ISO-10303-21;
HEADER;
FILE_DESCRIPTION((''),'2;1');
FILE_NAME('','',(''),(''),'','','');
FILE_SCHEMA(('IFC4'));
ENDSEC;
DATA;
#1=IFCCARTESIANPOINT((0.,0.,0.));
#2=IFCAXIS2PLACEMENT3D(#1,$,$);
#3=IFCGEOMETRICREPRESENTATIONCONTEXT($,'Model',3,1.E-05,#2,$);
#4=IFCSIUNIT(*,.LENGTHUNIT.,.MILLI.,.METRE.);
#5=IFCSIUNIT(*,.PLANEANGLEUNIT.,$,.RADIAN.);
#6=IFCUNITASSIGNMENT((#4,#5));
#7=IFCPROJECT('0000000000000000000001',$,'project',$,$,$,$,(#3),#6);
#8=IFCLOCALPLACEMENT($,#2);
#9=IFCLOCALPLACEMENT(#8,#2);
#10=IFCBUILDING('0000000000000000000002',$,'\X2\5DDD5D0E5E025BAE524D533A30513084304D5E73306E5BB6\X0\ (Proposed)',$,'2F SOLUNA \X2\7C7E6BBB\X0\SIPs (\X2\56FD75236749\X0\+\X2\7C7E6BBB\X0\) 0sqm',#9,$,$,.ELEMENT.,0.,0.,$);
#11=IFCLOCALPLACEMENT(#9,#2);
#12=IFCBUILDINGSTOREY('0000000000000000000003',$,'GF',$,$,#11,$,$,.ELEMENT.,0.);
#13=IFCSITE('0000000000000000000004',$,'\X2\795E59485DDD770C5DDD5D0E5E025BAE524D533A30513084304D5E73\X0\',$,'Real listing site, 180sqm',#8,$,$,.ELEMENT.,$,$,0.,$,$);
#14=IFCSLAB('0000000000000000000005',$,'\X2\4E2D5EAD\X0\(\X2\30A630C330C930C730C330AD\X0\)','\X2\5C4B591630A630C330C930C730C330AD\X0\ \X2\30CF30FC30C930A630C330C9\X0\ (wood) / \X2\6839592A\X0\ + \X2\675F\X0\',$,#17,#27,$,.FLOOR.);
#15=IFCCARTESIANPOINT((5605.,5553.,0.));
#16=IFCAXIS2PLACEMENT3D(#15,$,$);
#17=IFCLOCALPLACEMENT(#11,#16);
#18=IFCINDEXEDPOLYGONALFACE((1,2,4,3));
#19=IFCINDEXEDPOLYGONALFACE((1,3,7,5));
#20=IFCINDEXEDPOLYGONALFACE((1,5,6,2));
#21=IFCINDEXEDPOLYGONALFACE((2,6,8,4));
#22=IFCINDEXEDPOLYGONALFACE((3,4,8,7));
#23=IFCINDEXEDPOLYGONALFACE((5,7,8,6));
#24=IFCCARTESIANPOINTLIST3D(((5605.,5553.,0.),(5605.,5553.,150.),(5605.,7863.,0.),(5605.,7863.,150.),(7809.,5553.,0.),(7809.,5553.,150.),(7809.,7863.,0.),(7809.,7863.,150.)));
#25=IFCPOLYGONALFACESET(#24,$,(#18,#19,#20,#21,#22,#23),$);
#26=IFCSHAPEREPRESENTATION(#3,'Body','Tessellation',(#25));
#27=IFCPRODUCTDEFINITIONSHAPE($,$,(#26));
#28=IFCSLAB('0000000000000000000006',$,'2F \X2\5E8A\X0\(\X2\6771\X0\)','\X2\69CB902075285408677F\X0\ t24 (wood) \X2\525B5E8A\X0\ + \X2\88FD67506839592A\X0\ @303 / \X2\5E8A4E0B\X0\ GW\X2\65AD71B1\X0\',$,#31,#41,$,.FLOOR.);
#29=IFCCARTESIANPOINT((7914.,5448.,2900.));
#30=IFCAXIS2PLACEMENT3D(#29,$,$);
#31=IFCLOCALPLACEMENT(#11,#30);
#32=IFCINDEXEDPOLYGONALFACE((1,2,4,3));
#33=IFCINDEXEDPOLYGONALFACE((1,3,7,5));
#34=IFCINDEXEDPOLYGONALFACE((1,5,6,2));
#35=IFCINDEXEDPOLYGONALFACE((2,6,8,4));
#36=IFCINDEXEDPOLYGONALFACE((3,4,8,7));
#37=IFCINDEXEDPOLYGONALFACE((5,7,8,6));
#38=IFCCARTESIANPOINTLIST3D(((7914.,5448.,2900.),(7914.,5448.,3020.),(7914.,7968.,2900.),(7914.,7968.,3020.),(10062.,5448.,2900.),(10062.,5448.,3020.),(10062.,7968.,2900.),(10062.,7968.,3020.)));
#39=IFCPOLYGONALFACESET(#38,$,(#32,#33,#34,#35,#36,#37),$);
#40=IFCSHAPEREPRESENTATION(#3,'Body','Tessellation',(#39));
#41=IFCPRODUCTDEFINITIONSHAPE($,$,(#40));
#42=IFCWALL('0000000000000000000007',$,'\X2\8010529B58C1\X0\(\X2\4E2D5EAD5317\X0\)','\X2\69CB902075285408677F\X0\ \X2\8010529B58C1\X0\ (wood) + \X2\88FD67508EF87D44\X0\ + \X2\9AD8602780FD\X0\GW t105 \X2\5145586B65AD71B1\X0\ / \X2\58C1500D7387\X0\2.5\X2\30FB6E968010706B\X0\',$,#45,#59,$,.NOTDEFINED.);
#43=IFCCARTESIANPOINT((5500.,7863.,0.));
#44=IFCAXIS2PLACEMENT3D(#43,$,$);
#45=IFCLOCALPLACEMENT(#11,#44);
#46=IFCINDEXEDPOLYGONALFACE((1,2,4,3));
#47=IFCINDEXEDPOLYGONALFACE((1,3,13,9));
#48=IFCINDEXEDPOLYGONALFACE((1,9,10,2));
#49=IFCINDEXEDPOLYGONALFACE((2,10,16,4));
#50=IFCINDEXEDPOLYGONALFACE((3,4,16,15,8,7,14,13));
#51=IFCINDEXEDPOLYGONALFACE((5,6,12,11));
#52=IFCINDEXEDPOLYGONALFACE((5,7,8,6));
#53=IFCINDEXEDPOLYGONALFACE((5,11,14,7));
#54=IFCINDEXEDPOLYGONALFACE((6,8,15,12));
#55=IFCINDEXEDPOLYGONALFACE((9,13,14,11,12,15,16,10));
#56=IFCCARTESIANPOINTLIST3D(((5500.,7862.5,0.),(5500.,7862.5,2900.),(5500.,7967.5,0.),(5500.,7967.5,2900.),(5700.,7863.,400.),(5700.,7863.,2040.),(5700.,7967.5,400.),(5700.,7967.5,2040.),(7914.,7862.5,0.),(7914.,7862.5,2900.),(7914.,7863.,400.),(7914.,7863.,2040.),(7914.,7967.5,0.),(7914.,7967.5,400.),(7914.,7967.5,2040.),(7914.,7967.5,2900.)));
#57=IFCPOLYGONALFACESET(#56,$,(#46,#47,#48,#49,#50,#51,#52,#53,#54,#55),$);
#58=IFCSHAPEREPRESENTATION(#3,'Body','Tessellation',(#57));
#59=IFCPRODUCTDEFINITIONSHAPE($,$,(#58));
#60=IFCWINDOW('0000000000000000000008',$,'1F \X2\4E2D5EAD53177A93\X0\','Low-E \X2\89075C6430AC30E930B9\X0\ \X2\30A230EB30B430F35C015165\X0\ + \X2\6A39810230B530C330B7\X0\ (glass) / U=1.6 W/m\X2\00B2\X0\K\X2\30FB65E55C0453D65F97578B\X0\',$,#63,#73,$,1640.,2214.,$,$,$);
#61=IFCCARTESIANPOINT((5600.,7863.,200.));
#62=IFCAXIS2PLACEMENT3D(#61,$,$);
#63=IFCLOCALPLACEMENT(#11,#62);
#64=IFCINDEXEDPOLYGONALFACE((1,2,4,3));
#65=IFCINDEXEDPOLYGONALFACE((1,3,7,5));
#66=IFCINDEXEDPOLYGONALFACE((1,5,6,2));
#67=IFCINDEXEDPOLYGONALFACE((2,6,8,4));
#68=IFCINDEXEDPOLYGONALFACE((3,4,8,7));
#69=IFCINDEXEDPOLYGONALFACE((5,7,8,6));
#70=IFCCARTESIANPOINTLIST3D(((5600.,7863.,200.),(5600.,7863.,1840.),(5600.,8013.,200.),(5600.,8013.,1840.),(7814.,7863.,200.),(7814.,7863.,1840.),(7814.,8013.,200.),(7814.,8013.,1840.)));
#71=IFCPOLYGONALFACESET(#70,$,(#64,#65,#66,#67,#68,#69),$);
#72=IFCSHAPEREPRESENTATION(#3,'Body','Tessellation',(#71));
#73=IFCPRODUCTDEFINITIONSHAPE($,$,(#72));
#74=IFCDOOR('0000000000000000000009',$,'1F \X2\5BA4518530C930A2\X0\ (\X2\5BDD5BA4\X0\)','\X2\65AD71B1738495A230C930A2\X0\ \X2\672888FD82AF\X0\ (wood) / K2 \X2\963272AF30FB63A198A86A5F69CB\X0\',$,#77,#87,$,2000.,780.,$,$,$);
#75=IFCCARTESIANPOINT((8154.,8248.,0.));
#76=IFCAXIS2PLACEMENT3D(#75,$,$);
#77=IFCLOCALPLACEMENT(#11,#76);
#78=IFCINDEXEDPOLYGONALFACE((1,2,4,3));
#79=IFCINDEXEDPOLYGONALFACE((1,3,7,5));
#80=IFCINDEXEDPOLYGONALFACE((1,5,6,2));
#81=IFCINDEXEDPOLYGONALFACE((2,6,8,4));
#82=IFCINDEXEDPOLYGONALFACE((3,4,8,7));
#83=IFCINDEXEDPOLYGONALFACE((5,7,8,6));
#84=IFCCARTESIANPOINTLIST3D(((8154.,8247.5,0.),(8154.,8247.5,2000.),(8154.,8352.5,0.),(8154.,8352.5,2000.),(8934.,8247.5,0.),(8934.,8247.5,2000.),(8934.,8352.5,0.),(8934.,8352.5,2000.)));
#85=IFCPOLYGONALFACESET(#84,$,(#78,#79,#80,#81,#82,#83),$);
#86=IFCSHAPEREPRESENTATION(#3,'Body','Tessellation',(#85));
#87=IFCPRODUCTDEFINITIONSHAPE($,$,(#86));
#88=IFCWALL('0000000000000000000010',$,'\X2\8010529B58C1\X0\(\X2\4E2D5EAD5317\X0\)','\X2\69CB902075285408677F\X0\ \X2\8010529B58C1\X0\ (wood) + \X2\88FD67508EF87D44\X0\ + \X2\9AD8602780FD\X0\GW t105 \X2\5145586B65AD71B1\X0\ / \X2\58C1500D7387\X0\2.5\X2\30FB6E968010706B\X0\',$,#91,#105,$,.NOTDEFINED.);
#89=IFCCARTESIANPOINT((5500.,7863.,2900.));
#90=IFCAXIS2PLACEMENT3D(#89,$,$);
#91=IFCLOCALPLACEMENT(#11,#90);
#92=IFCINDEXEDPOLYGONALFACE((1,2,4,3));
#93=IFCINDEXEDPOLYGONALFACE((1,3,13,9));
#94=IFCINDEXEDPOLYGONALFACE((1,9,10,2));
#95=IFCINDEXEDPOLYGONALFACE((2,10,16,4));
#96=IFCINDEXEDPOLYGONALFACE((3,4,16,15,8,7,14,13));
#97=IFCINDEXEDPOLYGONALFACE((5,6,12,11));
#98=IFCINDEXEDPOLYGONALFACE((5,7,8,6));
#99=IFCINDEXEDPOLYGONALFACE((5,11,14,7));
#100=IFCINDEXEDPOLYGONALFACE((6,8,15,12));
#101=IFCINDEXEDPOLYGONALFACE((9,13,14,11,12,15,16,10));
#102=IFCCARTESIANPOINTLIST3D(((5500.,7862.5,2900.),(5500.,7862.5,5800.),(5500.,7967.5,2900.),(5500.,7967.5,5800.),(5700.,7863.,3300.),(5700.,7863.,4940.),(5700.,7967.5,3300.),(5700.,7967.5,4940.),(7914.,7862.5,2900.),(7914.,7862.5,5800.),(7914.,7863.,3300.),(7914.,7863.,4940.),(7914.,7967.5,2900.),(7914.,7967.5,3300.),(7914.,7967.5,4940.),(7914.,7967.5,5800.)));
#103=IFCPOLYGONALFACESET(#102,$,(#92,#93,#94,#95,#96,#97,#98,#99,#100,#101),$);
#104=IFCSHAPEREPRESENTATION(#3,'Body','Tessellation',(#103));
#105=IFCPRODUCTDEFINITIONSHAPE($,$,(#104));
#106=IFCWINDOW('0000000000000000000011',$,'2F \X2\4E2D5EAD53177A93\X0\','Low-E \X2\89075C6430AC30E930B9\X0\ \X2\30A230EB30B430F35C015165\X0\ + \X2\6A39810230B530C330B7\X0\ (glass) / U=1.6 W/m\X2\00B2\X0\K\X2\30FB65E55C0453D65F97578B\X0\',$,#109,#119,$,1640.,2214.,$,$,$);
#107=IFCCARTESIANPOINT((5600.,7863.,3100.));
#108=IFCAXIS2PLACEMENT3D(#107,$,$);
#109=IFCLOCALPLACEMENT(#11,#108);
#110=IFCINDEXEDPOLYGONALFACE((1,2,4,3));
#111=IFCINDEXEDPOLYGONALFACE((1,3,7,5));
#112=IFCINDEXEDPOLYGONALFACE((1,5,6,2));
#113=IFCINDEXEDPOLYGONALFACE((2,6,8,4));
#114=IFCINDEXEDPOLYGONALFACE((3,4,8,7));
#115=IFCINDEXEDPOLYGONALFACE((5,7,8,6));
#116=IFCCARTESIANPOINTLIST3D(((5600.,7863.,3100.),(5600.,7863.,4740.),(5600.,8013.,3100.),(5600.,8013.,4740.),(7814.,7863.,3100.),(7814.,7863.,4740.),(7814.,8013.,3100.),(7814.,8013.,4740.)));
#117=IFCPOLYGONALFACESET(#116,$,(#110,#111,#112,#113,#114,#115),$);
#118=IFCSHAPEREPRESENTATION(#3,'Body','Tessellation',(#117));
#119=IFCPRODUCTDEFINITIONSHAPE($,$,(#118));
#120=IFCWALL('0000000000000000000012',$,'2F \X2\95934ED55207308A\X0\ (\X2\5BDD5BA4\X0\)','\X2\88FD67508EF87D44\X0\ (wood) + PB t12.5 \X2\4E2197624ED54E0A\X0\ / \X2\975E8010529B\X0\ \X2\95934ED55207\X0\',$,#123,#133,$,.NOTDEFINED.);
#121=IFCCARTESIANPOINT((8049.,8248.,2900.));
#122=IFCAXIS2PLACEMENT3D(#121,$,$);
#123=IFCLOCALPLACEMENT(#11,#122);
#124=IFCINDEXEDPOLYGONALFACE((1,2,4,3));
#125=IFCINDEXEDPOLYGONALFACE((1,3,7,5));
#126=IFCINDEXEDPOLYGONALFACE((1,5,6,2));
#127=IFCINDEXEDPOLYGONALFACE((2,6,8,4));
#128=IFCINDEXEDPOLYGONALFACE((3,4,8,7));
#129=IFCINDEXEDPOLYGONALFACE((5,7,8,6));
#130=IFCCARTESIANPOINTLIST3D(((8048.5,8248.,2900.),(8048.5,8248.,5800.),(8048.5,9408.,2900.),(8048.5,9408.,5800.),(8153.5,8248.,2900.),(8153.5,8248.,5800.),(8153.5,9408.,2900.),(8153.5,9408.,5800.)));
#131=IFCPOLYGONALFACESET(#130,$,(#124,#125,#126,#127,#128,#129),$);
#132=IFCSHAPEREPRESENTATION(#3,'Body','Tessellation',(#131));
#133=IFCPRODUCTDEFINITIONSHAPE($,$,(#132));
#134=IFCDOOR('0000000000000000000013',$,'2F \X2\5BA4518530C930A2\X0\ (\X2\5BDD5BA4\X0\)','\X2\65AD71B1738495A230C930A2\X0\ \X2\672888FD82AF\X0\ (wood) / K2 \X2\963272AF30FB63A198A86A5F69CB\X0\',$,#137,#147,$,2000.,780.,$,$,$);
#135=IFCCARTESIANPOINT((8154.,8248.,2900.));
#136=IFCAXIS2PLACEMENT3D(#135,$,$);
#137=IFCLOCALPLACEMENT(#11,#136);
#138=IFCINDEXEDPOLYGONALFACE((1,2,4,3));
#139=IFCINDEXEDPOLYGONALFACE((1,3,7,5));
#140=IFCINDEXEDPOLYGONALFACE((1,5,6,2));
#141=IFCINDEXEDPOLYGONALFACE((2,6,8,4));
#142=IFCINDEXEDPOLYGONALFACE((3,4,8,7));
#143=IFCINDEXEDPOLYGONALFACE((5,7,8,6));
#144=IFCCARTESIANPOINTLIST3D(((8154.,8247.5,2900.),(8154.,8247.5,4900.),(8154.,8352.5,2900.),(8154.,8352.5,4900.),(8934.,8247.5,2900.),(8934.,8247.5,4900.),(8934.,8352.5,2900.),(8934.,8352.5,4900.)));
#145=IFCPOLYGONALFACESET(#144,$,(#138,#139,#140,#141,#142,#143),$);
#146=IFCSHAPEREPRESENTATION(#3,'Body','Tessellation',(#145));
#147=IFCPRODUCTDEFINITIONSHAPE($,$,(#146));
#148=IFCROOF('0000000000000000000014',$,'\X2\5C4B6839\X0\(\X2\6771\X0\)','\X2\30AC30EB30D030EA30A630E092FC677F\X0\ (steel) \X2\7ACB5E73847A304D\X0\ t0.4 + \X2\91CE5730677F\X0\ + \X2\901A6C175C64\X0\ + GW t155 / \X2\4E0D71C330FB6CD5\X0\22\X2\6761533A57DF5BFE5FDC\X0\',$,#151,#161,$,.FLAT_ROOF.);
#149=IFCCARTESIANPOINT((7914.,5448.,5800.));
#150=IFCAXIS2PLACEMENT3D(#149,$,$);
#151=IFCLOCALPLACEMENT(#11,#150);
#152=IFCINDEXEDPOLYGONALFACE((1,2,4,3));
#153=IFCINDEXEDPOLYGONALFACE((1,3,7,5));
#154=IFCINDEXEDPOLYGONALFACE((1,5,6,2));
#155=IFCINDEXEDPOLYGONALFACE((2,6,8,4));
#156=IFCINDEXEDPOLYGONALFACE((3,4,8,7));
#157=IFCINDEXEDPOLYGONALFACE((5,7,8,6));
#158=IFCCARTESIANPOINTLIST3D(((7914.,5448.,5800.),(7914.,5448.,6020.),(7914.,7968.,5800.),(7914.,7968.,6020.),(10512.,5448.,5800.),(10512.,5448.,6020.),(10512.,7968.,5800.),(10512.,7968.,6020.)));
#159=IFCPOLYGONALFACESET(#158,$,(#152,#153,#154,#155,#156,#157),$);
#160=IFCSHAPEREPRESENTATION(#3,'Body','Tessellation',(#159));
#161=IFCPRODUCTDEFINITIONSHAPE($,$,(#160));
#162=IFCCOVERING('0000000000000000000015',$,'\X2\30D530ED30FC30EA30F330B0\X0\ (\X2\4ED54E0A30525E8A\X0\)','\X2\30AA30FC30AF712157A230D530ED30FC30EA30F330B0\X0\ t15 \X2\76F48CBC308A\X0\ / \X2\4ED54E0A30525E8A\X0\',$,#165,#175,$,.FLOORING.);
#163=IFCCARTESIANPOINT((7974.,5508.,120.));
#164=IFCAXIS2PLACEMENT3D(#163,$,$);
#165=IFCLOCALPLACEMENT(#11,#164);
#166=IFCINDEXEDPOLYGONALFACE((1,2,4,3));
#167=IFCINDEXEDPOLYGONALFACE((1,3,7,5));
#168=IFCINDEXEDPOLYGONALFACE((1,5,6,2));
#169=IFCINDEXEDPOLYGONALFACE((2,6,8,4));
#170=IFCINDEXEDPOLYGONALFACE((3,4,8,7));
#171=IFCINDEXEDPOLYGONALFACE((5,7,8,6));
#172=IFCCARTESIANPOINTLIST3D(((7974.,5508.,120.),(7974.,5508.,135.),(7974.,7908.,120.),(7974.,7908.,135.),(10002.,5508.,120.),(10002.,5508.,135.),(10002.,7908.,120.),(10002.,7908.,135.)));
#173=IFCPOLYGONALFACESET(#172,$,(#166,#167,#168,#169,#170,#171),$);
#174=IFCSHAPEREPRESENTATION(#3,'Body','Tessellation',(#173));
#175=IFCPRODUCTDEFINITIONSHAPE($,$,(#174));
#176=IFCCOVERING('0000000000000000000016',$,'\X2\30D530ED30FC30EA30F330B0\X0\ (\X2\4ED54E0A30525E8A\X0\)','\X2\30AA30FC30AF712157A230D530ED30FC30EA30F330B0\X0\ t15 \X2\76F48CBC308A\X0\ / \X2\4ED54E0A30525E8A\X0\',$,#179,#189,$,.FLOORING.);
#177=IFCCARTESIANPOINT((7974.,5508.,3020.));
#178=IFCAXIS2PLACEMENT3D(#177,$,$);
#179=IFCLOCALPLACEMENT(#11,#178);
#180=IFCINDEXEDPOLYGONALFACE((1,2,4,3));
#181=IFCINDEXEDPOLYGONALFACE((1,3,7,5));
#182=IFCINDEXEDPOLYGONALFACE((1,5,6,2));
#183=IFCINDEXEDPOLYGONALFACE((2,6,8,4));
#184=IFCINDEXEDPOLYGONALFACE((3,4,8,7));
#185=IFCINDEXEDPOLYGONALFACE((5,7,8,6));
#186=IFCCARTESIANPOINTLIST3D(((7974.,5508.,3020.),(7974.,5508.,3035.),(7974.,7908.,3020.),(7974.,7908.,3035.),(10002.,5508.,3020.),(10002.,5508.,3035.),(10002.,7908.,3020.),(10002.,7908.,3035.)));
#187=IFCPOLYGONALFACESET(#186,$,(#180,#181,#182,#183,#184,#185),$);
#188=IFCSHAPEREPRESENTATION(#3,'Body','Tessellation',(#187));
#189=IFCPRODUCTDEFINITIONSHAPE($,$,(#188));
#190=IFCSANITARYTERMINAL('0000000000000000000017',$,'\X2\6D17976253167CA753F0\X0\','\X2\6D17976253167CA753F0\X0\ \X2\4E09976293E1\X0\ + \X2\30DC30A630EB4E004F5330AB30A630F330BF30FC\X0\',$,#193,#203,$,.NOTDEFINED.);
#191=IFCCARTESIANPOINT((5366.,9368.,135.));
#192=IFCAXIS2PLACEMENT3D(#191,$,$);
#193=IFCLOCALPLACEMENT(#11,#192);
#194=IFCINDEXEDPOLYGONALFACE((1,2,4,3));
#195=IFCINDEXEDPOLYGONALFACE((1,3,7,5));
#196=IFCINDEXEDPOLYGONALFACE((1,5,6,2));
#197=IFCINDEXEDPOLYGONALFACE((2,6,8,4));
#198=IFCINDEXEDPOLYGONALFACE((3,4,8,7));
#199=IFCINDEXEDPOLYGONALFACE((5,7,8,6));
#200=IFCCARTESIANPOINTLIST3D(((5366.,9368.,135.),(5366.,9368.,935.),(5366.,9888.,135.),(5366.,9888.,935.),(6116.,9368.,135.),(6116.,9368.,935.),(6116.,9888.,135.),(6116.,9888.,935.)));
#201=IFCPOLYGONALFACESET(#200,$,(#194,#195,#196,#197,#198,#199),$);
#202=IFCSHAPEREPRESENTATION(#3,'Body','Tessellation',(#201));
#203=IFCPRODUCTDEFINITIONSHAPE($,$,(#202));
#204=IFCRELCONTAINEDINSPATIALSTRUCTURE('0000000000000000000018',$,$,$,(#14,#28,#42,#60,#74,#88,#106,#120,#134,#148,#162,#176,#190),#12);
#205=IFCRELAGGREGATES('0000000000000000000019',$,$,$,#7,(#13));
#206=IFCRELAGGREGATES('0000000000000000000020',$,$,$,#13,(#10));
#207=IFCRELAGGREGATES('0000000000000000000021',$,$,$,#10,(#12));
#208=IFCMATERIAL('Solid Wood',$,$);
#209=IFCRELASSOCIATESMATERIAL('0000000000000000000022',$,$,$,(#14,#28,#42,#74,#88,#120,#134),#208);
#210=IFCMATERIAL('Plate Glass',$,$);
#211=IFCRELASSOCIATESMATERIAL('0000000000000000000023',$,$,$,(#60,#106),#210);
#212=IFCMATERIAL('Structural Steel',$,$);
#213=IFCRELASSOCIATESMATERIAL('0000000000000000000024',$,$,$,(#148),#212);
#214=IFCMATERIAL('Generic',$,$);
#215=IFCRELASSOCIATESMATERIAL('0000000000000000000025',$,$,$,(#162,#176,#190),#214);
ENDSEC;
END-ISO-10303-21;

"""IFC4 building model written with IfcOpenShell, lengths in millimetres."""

from ifc_helpers import new_model, si_unit, frame, frame_2d, origin, place, context, project, spatial, rectangle, extrude, material, element, fill, save


model = new_model("IFC4")

# Units and contexts
model_context = context("Model", 3, precision=1e-05, world=origin())
ifc_project = project(units=[si_unit("LENGTHUNIT", "METRE", prefix="MILLI"), si_unit("PLANEANGLEUNIT", "RADIAN")], contexts=[model_context])

# Site, building, storey
site_placement = place(None, origin())
site = spatial("IfcSite", under=ifc_project, at=site_placement, Name="神奈川県川崎市宮前区けやき平", ObjectType="Real listing site, 180sqm", CompositionType="ELEMENT", RefElevation=0.0)
building_placement = place(site_placement, origin())
building = spatial("IfcBuilding", under=site, at=building_placement, Name="川崎市宮前区けやき平の家 (Proposed)", ObjectType="2F SOLUNA 籾殻SIPs (国産杉+籾殻) 0sqm", CompositionType="ELEMENT", ElevationOfRefHeight=0.0, ElevationOfTerrain=0.0)
storey_placement = place(building_placement, origin())
storey = spatial("IfcBuildingStorey", under=building, at=storey_placement, Name="GF", CompositionType="ELEMENT", Elevation=0.0)

# Slabs
ifc_material_1 = material(Name="Solid Wood")
slab_1_placement = place(storey_placement, frame((5605.0, 5553.0, 0.0)))
element("IfcSlab", 1, at=slab_1_placement, inside=storey, material=ifc_material_1, Name="中庭(ウッドデッキ)", Description="屋外ウッドデッキ ハードウッド (wood) / 根太 + 束", PredefinedType="FLOOR", context=model_context, shape_type="SweptSolid", body=[
    extrude(rectangle(XDim=2204.0, YDim=2310.0, at=frame_2d((1102.0, 1155.0))), frame((5605.0, 5553.0, 0.0)), (0.0, 0.0, 1.0), 150.0),
])
slab_2_placement = place(storey_placement, frame((7914.0, 5448.0, 2900.0)))
element("IfcSlab", 2, at=slab_2_placement, inside=storey, material=ifc_material_1, Name="2F 床(東)", Description="構造用合板 t24 (wood) 剛床 + 製材根太 @303 / 床下 GW断熱", PredefinedType="FLOOR", context=model_context, shape_type="SweptSolid", body=[
    extrude(rectangle(XDim=2148.0, YDim=2520.0, at=frame_2d((1074.0, 1260.0))), frame((7914.0, 5448.0, 2900.0)), (0.0, 0.0, 1.0), 120.0),
])

# Wall, opening, window
wall_1_placement = place(storey_placement, frame((5500.0, 7863.0, 0.0)))
wall_1 = element("IfcWall", 3, at=wall_1_placement, inside=storey, material=ifc_material_1, Name="耐力壁(中庭北)", Description="構造用合板 耐力壁 (wood) + 製材軸組 + 高性能GW t105 充填断熱 / 壁倍率2.5・準耐火", PredefinedType="NOTDEFINED", context=model_context, shape_type="SweptSolid", body=[
    extrude(rectangle(XDim=2414.0, YDim=105.0, at=frame_2d((1207.0, 52.0))), frame((5500.0, 7863.0, 0.0)), (0.0, 0.0, 1.0), 2900.0),
])
opening_1_placement = place(storey_placement, frame((5600.0, 7863.0, 200.0)))
opening_1 = element("IfcOpeningElement", 4, at=opening_1_placement, cuts=wall_1, PredefinedType="NOTDEFINED", context=model_context, shape_type="SweptSolid", body=[
    extrude(rectangle(XDim=2214.0, YDim=150.0, at=frame_2d((1107.0, 75.0))), frame((5600.0, 7863.0, 200.0)), (0.0, 0.0, 1.0), 1640.0),
])
ifc_material_2 = material(Name="Plate Glass")
window_1_placement = place(storey_placement, frame((5600.0, 7863.0, 200.0)))
window_1 = element("IfcWindow", 5, at=window_1_placement, inside=storey, material=ifc_material_2, Name="1F 中庭北窓", Description="Low-E 複層ガラス アルゴン封入 + 樹脂サッシ (glass) / U=1.6 W/m²K・日射取得型", OverallHeight=1640.0, OverallWidth=2214.0, context=model_context, shape_type="SweptSolid", body=[
    extrude(rectangle(XDim=2214.0, YDim=150.0, at=frame_2d((1107.0, 75.0))), frame((5600.0, 7863.0, 200.0)), (0.0, 0.0, 1.0), 1640.0),
])
fill(opening_1, window_1)

# Door
door_1_placement = place(storey_placement, frame((8154.0, 8248.0, 0.0)))
element("IfcDoor", 6, at=door_1_placement, inside=storey, material=ifc_material_1, Name="1F 室内ドア (寝室)", Description="断熱玄関ドア 木製芯 (wood) / K2 防犯・採風機構", OverallHeight=2000.0, OverallWidth=780.0, context=model_context, shape_type="SweptSolid", body=[
    extrude(rectangle(XDim=780.0, YDim=105.0, at=frame_2d((390.0, 52.0))), frame((8154.0, 8248.0, 0.0)), (0.0, 0.0, 1.0), 2000.0),
])

# Wall, opening, window
wall_2_placement = place(storey_placement, frame((5500.0, 7863.0, 2900.0)))
wall_2 = element("IfcWall", 7, at=wall_2_placement, inside=storey, material=ifc_material_1, Name="耐力壁(中庭北)", Description="構造用合板 耐力壁 (wood) + 製材軸組 + 高性能GW t105 充填断熱 / 壁倍率2.5・準耐火", PredefinedType="NOTDEFINED", context=model_context, shape_type="SweptSolid", body=[
    extrude(rectangle(XDim=2414.0, YDim=105.0, at=frame_2d((1207.0, 52.0))), frame((5500.0, 7863.0, 2900.0)), (0.0, 0.0, 1.0), 2900.0),
])
opening_2_placement = place(storey_placement, frame((5600.0, 7863.0, 3100.0)))
opening_2 = element("IfcOpeningElement", 8, at=opening_2_placement, cuts=wall_2, PredefinedType="NOTDEFINED", context=model_context, shape_type="SweptSolid", body=[
    extrude(rectangle(XDim=2214.0, YDim=150.0, at=frame_2d((1107.0, 75.0))), frame((5600.0, 7863.0, 3100.0)), (0.0, 0.0, 1.0), 1640.0),
])
window_2_placement = place(storey_placement, frame((5600.0, 7863.0, 3100.0)))
window_2 = element("IfcWindow", 9, at=window_2_placement, inside=storey, material=ifc_material_2, Name="2F 中庭北窓", Description="Low-E 複層ガラス アルゴン封入 + 樹脂サッシ (glass) / U=1.6 W/m²K・日射取得型", OverallHeight=1640.0, OverallWidth=2214.0, context=model_context, shape_type="SweptSolid", body=[
    extrude(rectangle(XDim=2214.0, YDim=150.0, at=frame_2d((1107.0, 75.0))), frame((5600.0, 7863.0, 3100.0)), (0.0, 0.0, 1.0), 1640.0),
])
fill(opening_2, window_2)

# Wall
wall_3_placement = place(storey_placement, frame((8049.0, 8248.0, 2900.0)))
element("IfcWall", 10, at=wall_3_placement, inside=storey, material=ifc_material_1, Name="2F 間仕切り (寝室)", Description="製材軸組 (wood) + PB t12.5 両面仕上 / 非耐力 間仕切", PredefinedType="NOTDEFINED", context=model_context, shape_type="SweptSolid", body=[
    extrude(rectangle(XDim=105.0, YDim=1160.0, at=frame_2d((52.0, 580.0))), frame((8049.0, 8248.0, 2900.0)), (0.0, 0.0, 1.0), 2900.0),
])

# Door
door_2_placement = place(storey_placement, frame((8154.0, 8248.0, 2900.0)))
element("IfcDoor", 11, at=door_2_placement, inside=storey, material=ifc_material_1, Name="2F 室内ドア (寝室)", Description="断熱玄関ドア 木製芯 (wood) / K2 防犯・採風機構", OverallHeight=2000.0, OverallWidth=780.0, context=model_context, shape_type="SweptSolid", body=[
    extrude(rectangle(XDim=780.0, YDim=105.0, at=frame_2d((390.0, 52.0))), frame((8154.0, 8248.0, 2900.0)), (0.0, 0.0, 1.0), 2000.0),
])

# Roof
ifc_material_3 = material(Name="Structural Steel")
for number, where, name in (
    (12, (7914.0, 5448.0, 5800.0), "屋根(東)"),
):
    element("IfcRoof", number, at=place(storey_placement, frame(where)), inside=storey, material=ifc_material_3, Name=name, Description="ガルバリウム鋼板 (steel) 立平葺き t0.4 + 野地板 + 通気層 + GW t155 / 不燃・法22条区域対応", PredefinedType="FLAT_ROOF", context=model_context, shape_type="SweptSolid", body=[
        extrude(rectangle(XDim=2598.0, YDim=2520.0, at=frame_2d((1299.0, 1260.0))), frame((7914.0, 5448.0, 5800.0)), (0.0, 0.0, 1.0), 220.0),
    ])

# Coverings
ifc_material_4 = material(Name="Generic")
covering_1_placement = place(storey_placement, frame((7974.0, 5508.0, 120.0)))
element("IfcCovering", 13, at=covering_1_placement, inside=storey, material=ifc_material_4, Name="フローリング (仕上げ床)", Description="オーク無垢フローリング t15 直貼り / 仕上げ床", PredefinedType="FLOORING", context=model_context, shape_type="SweptSolid", body=[
    extrude(rectangle(XDim=2028.0, YDim=2400.0, at=frame_2d((1014.0, 1200.0))), frame((7974.0, 5508.0, 120.0)), (0.0, 0.0, 1.0), 15.0),
])
covering_2_placement = place(storey_placement, frame((7974.0, 5508.0, 3020.0)))
element("IfcCovering", 14, at=covering_2_placement, inside=storey, material=ifc_material_4, Name="フローリング (仕上げ床)", Description="オーク無垢フローリング t15 直貼り / 仕上げ床", PredefinedType="FLOORING", context=model_context, shape_type="SweptSolid", body=[
    extrude(rectangle(XDim=2028.0, YDim=2400.0, at=frame_2d((1014.0, 1200.0))), frame((7974.0, 5508.0, 3020.0)), (0.0, 0.0, 1.0), 15.0),
])

# Sanitary terminal
sanitary_terminal_1_placement = place(storey_placement, frame((5366.0, 9368.0, 135.0)))
element("IfcSanitaryTerminal", 15, at=sanitary_terminal_1_placement, inside=storey, material=ifc_material_4, Name="洗面化粧台", Description="洗面化粧台 三面鏡 + ボウル一体カウンター", PredefinedType="NOTDEFINED", context=model_context, shape_type="SweptSolid", body=[
    extrude(rectangle(XDim=750.0, YDim=520.0, at=frame_2d((375.0, 260.0))), frame((5366.0, 9368.0, 135.0)), (0.0, 0.0, 1.0), 800.0),
])

save(model, "model.ifc")
